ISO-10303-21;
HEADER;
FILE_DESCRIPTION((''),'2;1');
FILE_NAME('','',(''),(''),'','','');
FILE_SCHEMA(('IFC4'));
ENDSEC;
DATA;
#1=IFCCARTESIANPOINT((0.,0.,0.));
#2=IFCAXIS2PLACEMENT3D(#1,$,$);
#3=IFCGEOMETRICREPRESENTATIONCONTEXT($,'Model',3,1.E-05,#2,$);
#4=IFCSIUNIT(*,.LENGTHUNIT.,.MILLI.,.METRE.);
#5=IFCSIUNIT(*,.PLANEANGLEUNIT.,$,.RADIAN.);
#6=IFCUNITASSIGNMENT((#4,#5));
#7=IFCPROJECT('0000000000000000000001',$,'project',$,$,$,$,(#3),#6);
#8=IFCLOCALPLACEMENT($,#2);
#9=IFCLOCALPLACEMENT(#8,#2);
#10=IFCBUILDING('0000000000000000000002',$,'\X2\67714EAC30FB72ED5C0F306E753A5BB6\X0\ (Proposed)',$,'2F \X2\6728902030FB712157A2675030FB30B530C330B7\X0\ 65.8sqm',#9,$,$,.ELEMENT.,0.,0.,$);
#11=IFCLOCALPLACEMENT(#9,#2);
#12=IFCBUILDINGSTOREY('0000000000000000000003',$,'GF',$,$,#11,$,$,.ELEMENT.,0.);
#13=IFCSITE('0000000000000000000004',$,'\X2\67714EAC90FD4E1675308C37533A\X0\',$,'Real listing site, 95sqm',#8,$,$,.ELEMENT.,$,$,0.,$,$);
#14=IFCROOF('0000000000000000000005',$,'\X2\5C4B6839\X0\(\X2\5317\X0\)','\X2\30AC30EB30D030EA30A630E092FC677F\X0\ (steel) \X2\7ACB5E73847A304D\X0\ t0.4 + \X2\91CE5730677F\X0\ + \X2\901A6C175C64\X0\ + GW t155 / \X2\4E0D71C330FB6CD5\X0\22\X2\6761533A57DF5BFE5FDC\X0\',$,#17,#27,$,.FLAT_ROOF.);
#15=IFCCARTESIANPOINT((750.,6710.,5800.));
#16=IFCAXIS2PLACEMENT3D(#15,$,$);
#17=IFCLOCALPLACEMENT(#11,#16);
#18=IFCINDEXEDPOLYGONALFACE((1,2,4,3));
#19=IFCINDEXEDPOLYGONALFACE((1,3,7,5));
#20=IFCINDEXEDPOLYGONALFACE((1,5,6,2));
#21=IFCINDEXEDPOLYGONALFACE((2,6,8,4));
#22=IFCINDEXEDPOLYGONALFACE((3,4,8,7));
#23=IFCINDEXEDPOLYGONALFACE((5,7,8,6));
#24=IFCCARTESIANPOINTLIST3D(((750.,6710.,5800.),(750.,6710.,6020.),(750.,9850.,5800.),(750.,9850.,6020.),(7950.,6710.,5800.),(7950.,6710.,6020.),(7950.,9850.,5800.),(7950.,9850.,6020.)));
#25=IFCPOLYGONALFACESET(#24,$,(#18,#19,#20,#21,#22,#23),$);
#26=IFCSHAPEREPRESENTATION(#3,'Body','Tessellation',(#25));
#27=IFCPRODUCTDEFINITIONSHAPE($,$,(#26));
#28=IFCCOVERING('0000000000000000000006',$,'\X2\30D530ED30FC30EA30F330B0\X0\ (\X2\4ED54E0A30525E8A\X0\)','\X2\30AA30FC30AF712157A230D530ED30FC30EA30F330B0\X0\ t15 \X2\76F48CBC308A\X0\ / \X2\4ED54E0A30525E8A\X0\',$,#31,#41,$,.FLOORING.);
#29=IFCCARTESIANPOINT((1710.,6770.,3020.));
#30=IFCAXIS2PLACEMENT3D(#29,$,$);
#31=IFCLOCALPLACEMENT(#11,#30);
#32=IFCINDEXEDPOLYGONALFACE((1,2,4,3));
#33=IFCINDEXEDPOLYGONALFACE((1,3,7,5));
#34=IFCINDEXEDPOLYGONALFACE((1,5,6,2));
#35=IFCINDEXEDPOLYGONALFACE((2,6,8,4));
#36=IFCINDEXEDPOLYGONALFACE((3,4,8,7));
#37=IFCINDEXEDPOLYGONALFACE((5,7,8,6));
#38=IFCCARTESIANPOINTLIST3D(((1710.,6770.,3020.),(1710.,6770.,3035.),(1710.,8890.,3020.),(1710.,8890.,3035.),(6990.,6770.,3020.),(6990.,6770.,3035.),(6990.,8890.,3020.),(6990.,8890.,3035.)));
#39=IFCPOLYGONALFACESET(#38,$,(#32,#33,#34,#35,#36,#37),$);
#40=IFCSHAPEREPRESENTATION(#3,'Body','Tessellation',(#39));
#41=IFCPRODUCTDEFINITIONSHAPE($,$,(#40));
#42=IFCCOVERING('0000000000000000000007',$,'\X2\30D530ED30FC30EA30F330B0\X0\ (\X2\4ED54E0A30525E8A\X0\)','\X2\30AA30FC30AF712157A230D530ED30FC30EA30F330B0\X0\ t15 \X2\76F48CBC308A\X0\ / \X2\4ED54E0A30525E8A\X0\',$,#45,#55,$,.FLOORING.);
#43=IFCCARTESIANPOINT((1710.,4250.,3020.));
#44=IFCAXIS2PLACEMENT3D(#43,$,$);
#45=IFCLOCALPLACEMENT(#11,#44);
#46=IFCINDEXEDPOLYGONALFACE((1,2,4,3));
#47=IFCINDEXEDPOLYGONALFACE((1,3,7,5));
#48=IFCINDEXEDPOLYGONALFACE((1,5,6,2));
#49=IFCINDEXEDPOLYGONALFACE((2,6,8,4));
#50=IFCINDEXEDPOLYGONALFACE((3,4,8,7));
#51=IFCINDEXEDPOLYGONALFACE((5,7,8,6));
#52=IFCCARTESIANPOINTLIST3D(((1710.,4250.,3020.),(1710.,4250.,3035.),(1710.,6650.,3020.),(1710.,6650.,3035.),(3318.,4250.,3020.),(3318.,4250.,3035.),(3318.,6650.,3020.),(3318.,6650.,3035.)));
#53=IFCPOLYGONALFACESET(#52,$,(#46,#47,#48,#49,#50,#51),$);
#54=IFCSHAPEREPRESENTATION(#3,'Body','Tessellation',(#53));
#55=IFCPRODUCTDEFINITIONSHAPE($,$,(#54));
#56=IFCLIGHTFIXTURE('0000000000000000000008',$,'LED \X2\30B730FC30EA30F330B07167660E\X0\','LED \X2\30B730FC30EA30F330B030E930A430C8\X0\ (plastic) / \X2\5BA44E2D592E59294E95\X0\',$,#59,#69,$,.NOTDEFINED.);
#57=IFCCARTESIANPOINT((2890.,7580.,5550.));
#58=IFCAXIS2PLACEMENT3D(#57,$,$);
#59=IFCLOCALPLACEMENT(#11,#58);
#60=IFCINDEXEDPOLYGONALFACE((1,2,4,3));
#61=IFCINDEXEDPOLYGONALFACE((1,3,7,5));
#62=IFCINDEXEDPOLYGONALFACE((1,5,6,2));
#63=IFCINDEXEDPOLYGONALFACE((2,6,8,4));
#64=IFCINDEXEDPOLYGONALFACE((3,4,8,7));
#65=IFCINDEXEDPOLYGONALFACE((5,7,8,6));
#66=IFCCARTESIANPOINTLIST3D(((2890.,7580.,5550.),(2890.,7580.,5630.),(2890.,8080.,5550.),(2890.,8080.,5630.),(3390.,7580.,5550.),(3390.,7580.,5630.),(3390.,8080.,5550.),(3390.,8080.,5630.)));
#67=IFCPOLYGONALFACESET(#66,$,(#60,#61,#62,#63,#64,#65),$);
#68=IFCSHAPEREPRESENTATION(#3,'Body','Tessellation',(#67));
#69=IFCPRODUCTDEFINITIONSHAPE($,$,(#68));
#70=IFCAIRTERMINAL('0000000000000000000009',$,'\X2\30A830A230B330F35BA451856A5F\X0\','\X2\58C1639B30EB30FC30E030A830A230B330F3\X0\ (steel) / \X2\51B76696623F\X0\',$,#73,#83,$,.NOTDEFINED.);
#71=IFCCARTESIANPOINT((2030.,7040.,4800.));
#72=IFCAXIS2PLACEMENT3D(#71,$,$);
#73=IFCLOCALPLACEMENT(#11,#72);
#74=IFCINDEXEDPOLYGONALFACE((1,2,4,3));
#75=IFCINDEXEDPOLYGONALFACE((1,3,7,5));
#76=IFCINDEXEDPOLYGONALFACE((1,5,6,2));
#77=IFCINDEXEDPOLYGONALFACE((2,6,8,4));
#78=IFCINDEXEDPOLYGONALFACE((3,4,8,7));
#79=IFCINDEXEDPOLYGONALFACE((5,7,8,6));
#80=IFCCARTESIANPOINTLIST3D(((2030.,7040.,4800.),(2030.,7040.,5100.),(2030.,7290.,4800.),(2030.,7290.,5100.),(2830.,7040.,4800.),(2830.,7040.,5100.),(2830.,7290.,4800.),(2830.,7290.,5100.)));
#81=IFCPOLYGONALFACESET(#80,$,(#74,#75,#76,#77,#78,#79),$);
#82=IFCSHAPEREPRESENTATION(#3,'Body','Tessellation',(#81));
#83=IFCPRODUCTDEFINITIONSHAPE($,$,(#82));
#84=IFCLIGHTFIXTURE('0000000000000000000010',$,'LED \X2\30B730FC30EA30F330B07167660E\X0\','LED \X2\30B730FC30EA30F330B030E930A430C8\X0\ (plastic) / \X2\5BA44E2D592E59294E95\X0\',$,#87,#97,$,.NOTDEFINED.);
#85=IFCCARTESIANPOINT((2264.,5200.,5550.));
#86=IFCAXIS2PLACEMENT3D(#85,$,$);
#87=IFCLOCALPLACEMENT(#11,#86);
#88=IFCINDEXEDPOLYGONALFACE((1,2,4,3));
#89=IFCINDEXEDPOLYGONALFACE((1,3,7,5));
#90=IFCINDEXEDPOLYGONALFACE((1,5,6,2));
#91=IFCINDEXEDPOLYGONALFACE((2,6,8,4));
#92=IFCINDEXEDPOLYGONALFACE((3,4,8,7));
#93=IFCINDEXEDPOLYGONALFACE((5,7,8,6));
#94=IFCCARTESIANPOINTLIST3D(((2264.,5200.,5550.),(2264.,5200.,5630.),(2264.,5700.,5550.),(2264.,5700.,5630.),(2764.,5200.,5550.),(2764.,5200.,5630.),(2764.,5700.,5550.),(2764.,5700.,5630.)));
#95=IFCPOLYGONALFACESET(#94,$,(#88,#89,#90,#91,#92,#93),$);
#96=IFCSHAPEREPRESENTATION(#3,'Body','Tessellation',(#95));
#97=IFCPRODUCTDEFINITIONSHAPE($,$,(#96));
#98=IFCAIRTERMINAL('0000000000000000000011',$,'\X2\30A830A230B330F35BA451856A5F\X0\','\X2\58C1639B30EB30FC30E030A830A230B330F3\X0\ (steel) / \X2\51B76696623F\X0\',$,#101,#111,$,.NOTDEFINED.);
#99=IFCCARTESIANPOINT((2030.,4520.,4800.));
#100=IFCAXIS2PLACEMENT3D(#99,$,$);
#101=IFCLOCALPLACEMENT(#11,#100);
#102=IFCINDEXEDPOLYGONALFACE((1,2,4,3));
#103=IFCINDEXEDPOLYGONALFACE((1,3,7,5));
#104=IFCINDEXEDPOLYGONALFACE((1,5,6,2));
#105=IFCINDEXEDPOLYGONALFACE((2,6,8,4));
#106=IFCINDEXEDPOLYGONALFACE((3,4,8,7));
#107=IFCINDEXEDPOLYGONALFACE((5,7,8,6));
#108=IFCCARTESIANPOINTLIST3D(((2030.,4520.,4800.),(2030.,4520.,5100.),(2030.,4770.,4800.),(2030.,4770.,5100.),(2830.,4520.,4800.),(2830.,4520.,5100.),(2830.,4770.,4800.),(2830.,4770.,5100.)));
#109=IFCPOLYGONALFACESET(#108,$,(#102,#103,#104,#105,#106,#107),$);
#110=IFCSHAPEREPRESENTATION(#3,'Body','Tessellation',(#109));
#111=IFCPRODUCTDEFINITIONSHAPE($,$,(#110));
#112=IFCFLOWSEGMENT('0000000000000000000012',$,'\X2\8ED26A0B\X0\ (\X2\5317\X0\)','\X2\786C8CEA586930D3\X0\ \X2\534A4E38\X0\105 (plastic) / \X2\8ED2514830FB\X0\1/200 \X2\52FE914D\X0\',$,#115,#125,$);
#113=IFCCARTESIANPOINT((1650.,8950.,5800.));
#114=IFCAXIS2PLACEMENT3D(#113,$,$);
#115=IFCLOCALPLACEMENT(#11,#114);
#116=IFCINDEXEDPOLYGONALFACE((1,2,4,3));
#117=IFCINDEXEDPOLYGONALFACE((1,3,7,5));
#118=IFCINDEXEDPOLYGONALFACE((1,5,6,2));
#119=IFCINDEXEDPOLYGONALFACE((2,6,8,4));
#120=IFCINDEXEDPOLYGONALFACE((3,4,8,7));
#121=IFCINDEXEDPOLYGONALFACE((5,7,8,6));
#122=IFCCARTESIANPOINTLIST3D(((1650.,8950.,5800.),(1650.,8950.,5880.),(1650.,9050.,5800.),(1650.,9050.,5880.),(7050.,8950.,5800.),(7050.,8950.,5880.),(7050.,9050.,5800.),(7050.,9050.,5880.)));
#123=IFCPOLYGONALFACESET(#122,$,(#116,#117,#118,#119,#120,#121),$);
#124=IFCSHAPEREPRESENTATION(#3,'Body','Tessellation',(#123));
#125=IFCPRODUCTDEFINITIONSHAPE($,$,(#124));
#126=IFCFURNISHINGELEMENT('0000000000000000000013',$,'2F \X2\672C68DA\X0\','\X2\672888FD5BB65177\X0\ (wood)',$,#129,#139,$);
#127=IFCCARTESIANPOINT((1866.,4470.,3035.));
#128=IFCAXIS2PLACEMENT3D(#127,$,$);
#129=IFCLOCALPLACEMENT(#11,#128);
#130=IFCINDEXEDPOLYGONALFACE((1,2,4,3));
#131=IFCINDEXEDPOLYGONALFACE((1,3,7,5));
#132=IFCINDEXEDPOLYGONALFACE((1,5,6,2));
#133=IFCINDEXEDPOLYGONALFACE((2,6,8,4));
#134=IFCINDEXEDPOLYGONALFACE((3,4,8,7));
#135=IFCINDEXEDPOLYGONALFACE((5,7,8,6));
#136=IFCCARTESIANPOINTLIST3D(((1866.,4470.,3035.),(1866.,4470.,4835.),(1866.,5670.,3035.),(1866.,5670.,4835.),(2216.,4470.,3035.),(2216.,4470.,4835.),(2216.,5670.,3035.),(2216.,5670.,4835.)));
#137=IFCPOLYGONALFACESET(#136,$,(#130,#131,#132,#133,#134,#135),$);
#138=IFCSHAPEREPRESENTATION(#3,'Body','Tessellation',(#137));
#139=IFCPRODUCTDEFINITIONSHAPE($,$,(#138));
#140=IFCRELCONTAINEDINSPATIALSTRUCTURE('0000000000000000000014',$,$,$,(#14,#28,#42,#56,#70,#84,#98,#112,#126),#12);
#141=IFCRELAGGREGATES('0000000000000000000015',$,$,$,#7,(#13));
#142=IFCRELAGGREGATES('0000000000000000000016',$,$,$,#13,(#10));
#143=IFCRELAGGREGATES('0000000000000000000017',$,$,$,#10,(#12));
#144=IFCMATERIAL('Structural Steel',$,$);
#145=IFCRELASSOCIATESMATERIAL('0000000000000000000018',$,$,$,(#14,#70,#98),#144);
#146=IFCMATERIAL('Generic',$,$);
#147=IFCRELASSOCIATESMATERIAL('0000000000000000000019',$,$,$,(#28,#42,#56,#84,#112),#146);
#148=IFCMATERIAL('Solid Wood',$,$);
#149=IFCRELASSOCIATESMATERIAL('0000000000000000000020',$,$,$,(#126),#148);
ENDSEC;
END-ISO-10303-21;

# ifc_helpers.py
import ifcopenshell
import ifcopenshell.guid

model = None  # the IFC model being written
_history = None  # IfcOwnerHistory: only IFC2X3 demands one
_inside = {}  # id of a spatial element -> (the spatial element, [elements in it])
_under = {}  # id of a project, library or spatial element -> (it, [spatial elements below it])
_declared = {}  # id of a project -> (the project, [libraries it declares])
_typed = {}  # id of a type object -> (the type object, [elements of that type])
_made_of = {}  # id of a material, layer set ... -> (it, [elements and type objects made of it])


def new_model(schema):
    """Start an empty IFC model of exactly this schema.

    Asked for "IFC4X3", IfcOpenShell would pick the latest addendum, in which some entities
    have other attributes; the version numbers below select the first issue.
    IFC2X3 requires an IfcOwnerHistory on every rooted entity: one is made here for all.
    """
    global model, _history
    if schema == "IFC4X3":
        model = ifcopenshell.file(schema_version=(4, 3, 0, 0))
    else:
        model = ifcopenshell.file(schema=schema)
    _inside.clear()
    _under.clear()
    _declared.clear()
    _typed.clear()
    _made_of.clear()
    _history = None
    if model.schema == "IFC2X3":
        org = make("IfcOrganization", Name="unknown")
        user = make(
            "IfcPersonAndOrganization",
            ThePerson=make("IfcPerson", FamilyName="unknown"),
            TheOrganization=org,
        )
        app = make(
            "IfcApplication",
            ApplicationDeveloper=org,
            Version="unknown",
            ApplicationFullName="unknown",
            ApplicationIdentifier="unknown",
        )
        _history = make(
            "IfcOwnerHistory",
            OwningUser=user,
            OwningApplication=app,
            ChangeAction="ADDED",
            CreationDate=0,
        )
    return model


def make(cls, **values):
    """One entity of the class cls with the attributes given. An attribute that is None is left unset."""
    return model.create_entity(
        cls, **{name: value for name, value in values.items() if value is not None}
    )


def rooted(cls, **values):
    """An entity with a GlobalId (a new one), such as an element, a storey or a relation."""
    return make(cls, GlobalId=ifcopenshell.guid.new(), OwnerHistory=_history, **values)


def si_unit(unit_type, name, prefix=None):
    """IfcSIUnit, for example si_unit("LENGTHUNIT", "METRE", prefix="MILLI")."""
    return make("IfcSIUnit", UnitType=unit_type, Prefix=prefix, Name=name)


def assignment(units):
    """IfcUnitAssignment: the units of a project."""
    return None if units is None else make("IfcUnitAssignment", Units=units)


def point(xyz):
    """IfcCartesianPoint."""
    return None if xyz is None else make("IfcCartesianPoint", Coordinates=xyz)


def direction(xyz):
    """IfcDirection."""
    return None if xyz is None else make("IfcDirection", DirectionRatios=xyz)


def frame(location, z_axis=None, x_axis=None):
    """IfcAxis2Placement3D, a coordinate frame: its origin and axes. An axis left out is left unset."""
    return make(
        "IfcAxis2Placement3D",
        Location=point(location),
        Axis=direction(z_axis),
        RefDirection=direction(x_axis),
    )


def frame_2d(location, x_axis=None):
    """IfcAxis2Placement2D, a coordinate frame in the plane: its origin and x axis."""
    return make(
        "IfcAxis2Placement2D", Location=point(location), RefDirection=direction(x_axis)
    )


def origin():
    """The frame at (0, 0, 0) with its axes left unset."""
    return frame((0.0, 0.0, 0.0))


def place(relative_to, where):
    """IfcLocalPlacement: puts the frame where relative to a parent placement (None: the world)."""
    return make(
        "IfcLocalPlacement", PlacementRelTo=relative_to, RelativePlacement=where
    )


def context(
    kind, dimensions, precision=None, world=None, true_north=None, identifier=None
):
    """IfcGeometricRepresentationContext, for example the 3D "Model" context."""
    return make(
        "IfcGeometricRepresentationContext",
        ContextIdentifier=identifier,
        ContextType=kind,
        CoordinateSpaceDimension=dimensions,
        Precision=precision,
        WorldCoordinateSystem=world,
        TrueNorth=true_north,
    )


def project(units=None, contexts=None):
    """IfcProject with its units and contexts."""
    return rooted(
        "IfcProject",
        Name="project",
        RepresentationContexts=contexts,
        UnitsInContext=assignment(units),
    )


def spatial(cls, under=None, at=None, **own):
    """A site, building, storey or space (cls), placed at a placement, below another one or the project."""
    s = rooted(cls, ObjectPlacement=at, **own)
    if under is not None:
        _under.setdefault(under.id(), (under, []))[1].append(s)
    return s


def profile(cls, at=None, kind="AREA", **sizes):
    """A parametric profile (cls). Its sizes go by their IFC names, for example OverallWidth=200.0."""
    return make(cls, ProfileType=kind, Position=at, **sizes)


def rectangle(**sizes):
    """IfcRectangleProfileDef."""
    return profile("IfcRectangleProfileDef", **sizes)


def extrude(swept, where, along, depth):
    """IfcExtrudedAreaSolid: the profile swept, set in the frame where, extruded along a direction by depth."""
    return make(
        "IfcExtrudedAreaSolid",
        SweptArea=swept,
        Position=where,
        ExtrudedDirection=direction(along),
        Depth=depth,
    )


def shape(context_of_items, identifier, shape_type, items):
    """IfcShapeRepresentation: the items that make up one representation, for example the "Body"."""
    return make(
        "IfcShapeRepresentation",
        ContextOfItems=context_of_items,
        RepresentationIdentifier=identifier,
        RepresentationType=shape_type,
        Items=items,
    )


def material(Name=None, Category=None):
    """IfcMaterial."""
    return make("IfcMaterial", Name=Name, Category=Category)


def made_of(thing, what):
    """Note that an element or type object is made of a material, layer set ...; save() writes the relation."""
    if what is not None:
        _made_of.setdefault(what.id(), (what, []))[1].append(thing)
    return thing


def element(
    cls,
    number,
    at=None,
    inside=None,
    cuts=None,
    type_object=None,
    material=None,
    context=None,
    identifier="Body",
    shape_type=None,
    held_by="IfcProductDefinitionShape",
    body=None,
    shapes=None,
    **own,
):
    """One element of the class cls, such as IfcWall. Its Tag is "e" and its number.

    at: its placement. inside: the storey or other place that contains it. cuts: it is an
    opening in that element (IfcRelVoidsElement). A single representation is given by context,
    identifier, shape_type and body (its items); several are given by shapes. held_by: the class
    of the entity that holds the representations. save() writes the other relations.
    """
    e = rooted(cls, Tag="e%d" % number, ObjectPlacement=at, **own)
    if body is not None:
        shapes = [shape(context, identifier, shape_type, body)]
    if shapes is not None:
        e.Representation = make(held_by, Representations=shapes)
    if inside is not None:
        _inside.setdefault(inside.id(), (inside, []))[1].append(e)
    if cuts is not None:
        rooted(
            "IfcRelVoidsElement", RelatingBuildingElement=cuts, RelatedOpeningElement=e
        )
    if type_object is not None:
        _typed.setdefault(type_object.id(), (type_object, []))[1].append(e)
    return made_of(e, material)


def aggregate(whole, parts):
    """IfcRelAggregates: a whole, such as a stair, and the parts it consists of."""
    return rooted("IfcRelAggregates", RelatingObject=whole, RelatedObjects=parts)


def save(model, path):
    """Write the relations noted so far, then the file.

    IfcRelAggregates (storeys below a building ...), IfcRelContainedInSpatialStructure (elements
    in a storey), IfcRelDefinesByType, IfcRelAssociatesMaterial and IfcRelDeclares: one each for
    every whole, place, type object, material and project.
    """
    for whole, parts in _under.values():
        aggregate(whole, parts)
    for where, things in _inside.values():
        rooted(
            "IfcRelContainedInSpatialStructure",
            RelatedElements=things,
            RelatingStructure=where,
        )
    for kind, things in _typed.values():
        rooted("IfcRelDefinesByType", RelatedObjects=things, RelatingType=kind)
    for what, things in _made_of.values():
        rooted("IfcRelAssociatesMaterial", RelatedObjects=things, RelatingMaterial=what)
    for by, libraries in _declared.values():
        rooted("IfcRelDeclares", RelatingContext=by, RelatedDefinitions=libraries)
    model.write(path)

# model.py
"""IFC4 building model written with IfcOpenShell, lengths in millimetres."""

from ifc_helpers import new_model, si_unit, frame, frame_2d, origin, place, context, project, spatial, rectangle, extrude, material, element, save


model = new_model("IFC4")

# Units and contexts
model_context = context("Model", 3, precision=1e-05, world=origin())
ifc_project = project(units=[si_unit("LENGTHUNIT", "METRE", prefix="MILLI"), si_unit("PLANEANGLEUNIT", "RADIAN")], contexts=[model_context])

# Site, building, storey
site_placement = place(None, origin())
site = spatial("IfcSite", under=ifc_project, at=site_placement, Name="東京都世田谷区", ObjectType="Real listing site, 95sqm", CompositionType="ELEMENT", RefElevation=0.0)
building_placement = place(site_placement, origin())
building = spatial("IfcBuilding", under=site, at=building_placement, Name="東京・狭小の町家 (Proposed)", ObjectType="2F 木造・無垢材・サッシ 65.8sqm", CompositionType="ELEMENT", ElevationOfRefHeight=0.0, ElevationOfTerrain=0.0)
storey_placement = place(building_placement, origin())
storey = spatial("IfcBuildingStorey", under=building, at=storey_placement, Name="GF", CompositionType="ELEMENT", Elevation=0.0)

# Shared definitions
ifc_material_1 = material(Name="Solid Wood")

# Roof
ifc_material_2 = material(Name="Structural Steel")
for number, where, name in (
    (1, (750.0, 6710.0, 5800.0), "屋根(北)"),
):
    element("IfcRoof", number, at=place(storey_placement, frame(where)), inside=storey, material=ifc_material_2, Name=name, Description="ガルバリウム鋼板 (steel) 立平葺き t0.4 + 野地板 + 通気層 + GW t155 / 不燃・法22条区域対応", PredefinedType="FLAT_ROOF", context=model_context, shape_type="SweptSolid", body=[
        extrude(rectangle(XDim=7200.0, YDim=3140.0, at=frame_2d((3600.0, 1570.0))), frame((750.0, 6710.0, 5800.0)), (0.0, 0.0, 1.0), 220.0),
    ])

# Coverings
ifc_material_3 = material(Name="Generic")
covering_1_placement = place(storey_placement, frame((1710.0, 6770.0, 3020.0)))
element("IfcCovering", 2, at=covering_1_placement, inside=storey, material=ifc_material_3, Name="フローリング (仕上げ床)", Description="オーク無垢フローリング t15 直貼り / 仕上げ床", PredefinedType="FLOORING", context=model_context, shape_type="SweptSolid", body=[
    extrude(rectangle(XDim=5280.0, YDim=2120.0, at=frame_2d((2640.0, 1060.0))), frame((1710.0, 6770.0, 3020.0)), (0.0, 0.0, 1.0), 15.0),
])
covering_2_placement = place(storey_placement, frame((1710.0, 4250.0, 3020.0)))
element("IfcCovering", 3, at=covering_2_placement, inside=storey, material=ifc_material_3, Name="フローリング (仕上げ床)", Description="オーク無垢フローリング t15 直貼り / 仕上げ床", PredefinedType="FLOORING", context=model_context, shape_type="SweptSolid", body=[
    extrude(rectangle(XDim=1608.0, YDim=2400.0, at=frame_2d((804.0, 1200.0))), frame((1710.0, 4250.0, 3020.0)), (0.0, 0.0, 1.0), 15.0),
])

# Light fixture
light_fixture_1_placement = place(storey_placement, frame((2890.0, 7580.0, 5550.0)))
element("IfcLightFixture", 4, at=light_fixture_1_placement, inside=storey, material=ifc_material_3, Name="LED シーリング照明", Description="LED シーリングライト (plastic) / 室中央天井", PredefinedType="NOTDEFINED", context=model_context, shape_type="SweptSolid", body=[
    extrude(rectangle(XDim=500.0, YDim=500.0, at=frame_2d((250.0, 250.0))), frame((2890.0, 7580.0, 5550.0)), (0.0, 0.0, 1.0), 80.0),
])

# Air terminal
air_terminal_1_placement = place(storey_placement, frame((2030.0, 7040.0, 4800.0)))
element("IfcAirTerminal", 5, at=air_terminal_1_placement, inside=storey, material=ifc_material_2, Name="エアコン室内機", Description="壁掛ルームエアコン (steel) / 冷暖房", PredefinedType="NOTDEFINED", context=model_context, shape_type="SweptSolid", body=[
    extrude(rectangle(XDim=800.0, YDim=250.0, at=frame_2d((400.0, 125.0))), frame((2030.0, 7040.0, 4800.0)), (0.0, 0.0, 1.0), 300.0),
])

# Light fixture
light_fixture_2_placement = place(storey_placement, frame((2264.0, 5200.0, 5550.0)))
element("IfcLightFixture", 6, at=light_fixture_2_placement, inside=storey, material=ifc_material_3, Name="LED シーリング照明", Description="LED シーリングライト (plastic) / 室中央天井", PredefinedType="NOTDEFINED", context=model_context, shape_type="SweptSolid", body=[
    extrude(rectangle(XDim=500.0, YDim=500.0, at=frame_2d((250.0, 250.0))), frame((2264.0, 5200.0, 5550.0)), (0.0, 0.0, 1.0), 80.0),
])

# Air terminal
air_terminal_2_placement = place(storey_placement, frame((2030.0, 4520.0, 4800.0)))
element("IfcAirTerminal", 7, at=air_terminal_2_placement, inside=storey, material=ifc_material_2, Name="エアコン室内機", Description="壁掛ルームエアコン (steel) / 冷暖房", PredefinedType="NOTDEFINED", context=model_context, shape_type="SweptSolid", body=[
    extrude(rectangle(XDim=800.0, YDim=250.0, at=frame_2d((400.0, 125.0))), frame((2030.0, 4520.0, 4800.0)), (0.0, 0.0, 1.0), 300.0),
])

# Flow segment
flow_segment_placement = place(storey_placement, frame((1650.0, 8950.0, 5800.0)))
element("IfcFlowSegment", 8, at=flow_segment_placement, inside=storey, material=ifc_material_3, Name="軒樋 (北)", Description="硬質塩ビ 半丸105 (plastic) / 軒先・1/200 勾配", context=model_context, shape_type="SweptSolid", body=[
    extrude(rectangle(XDim=5400.0, YDim=100.0, at=frame_2d((2700.0, 50.0))), frame((1650.0, 8950.0, 5800.0)), (0.0, 0.0, 1.0), 80.0),
])

# Furnishing element
furnishing_placement = place(storey_placement, frame((1866.0, 4470.0, 3035.0)))
element("IfcFurnishingElement", 9, at=furnishing_placement, inside=storey, material=ifc_material_1, Name="2F 本棚", Description="木製家具 (wood)", context=model_context, shape_type="SweptSolid", body=[
    extrude(rectangle(XDim=350.0, YDim=1200.0, at=frame_2d((175.0, 600.0))), frame((1866.0, 4470.0, 3035.0)), (0.0, 0.0, 1.0), 1800.0),
])

save(model, "model.ifc")
